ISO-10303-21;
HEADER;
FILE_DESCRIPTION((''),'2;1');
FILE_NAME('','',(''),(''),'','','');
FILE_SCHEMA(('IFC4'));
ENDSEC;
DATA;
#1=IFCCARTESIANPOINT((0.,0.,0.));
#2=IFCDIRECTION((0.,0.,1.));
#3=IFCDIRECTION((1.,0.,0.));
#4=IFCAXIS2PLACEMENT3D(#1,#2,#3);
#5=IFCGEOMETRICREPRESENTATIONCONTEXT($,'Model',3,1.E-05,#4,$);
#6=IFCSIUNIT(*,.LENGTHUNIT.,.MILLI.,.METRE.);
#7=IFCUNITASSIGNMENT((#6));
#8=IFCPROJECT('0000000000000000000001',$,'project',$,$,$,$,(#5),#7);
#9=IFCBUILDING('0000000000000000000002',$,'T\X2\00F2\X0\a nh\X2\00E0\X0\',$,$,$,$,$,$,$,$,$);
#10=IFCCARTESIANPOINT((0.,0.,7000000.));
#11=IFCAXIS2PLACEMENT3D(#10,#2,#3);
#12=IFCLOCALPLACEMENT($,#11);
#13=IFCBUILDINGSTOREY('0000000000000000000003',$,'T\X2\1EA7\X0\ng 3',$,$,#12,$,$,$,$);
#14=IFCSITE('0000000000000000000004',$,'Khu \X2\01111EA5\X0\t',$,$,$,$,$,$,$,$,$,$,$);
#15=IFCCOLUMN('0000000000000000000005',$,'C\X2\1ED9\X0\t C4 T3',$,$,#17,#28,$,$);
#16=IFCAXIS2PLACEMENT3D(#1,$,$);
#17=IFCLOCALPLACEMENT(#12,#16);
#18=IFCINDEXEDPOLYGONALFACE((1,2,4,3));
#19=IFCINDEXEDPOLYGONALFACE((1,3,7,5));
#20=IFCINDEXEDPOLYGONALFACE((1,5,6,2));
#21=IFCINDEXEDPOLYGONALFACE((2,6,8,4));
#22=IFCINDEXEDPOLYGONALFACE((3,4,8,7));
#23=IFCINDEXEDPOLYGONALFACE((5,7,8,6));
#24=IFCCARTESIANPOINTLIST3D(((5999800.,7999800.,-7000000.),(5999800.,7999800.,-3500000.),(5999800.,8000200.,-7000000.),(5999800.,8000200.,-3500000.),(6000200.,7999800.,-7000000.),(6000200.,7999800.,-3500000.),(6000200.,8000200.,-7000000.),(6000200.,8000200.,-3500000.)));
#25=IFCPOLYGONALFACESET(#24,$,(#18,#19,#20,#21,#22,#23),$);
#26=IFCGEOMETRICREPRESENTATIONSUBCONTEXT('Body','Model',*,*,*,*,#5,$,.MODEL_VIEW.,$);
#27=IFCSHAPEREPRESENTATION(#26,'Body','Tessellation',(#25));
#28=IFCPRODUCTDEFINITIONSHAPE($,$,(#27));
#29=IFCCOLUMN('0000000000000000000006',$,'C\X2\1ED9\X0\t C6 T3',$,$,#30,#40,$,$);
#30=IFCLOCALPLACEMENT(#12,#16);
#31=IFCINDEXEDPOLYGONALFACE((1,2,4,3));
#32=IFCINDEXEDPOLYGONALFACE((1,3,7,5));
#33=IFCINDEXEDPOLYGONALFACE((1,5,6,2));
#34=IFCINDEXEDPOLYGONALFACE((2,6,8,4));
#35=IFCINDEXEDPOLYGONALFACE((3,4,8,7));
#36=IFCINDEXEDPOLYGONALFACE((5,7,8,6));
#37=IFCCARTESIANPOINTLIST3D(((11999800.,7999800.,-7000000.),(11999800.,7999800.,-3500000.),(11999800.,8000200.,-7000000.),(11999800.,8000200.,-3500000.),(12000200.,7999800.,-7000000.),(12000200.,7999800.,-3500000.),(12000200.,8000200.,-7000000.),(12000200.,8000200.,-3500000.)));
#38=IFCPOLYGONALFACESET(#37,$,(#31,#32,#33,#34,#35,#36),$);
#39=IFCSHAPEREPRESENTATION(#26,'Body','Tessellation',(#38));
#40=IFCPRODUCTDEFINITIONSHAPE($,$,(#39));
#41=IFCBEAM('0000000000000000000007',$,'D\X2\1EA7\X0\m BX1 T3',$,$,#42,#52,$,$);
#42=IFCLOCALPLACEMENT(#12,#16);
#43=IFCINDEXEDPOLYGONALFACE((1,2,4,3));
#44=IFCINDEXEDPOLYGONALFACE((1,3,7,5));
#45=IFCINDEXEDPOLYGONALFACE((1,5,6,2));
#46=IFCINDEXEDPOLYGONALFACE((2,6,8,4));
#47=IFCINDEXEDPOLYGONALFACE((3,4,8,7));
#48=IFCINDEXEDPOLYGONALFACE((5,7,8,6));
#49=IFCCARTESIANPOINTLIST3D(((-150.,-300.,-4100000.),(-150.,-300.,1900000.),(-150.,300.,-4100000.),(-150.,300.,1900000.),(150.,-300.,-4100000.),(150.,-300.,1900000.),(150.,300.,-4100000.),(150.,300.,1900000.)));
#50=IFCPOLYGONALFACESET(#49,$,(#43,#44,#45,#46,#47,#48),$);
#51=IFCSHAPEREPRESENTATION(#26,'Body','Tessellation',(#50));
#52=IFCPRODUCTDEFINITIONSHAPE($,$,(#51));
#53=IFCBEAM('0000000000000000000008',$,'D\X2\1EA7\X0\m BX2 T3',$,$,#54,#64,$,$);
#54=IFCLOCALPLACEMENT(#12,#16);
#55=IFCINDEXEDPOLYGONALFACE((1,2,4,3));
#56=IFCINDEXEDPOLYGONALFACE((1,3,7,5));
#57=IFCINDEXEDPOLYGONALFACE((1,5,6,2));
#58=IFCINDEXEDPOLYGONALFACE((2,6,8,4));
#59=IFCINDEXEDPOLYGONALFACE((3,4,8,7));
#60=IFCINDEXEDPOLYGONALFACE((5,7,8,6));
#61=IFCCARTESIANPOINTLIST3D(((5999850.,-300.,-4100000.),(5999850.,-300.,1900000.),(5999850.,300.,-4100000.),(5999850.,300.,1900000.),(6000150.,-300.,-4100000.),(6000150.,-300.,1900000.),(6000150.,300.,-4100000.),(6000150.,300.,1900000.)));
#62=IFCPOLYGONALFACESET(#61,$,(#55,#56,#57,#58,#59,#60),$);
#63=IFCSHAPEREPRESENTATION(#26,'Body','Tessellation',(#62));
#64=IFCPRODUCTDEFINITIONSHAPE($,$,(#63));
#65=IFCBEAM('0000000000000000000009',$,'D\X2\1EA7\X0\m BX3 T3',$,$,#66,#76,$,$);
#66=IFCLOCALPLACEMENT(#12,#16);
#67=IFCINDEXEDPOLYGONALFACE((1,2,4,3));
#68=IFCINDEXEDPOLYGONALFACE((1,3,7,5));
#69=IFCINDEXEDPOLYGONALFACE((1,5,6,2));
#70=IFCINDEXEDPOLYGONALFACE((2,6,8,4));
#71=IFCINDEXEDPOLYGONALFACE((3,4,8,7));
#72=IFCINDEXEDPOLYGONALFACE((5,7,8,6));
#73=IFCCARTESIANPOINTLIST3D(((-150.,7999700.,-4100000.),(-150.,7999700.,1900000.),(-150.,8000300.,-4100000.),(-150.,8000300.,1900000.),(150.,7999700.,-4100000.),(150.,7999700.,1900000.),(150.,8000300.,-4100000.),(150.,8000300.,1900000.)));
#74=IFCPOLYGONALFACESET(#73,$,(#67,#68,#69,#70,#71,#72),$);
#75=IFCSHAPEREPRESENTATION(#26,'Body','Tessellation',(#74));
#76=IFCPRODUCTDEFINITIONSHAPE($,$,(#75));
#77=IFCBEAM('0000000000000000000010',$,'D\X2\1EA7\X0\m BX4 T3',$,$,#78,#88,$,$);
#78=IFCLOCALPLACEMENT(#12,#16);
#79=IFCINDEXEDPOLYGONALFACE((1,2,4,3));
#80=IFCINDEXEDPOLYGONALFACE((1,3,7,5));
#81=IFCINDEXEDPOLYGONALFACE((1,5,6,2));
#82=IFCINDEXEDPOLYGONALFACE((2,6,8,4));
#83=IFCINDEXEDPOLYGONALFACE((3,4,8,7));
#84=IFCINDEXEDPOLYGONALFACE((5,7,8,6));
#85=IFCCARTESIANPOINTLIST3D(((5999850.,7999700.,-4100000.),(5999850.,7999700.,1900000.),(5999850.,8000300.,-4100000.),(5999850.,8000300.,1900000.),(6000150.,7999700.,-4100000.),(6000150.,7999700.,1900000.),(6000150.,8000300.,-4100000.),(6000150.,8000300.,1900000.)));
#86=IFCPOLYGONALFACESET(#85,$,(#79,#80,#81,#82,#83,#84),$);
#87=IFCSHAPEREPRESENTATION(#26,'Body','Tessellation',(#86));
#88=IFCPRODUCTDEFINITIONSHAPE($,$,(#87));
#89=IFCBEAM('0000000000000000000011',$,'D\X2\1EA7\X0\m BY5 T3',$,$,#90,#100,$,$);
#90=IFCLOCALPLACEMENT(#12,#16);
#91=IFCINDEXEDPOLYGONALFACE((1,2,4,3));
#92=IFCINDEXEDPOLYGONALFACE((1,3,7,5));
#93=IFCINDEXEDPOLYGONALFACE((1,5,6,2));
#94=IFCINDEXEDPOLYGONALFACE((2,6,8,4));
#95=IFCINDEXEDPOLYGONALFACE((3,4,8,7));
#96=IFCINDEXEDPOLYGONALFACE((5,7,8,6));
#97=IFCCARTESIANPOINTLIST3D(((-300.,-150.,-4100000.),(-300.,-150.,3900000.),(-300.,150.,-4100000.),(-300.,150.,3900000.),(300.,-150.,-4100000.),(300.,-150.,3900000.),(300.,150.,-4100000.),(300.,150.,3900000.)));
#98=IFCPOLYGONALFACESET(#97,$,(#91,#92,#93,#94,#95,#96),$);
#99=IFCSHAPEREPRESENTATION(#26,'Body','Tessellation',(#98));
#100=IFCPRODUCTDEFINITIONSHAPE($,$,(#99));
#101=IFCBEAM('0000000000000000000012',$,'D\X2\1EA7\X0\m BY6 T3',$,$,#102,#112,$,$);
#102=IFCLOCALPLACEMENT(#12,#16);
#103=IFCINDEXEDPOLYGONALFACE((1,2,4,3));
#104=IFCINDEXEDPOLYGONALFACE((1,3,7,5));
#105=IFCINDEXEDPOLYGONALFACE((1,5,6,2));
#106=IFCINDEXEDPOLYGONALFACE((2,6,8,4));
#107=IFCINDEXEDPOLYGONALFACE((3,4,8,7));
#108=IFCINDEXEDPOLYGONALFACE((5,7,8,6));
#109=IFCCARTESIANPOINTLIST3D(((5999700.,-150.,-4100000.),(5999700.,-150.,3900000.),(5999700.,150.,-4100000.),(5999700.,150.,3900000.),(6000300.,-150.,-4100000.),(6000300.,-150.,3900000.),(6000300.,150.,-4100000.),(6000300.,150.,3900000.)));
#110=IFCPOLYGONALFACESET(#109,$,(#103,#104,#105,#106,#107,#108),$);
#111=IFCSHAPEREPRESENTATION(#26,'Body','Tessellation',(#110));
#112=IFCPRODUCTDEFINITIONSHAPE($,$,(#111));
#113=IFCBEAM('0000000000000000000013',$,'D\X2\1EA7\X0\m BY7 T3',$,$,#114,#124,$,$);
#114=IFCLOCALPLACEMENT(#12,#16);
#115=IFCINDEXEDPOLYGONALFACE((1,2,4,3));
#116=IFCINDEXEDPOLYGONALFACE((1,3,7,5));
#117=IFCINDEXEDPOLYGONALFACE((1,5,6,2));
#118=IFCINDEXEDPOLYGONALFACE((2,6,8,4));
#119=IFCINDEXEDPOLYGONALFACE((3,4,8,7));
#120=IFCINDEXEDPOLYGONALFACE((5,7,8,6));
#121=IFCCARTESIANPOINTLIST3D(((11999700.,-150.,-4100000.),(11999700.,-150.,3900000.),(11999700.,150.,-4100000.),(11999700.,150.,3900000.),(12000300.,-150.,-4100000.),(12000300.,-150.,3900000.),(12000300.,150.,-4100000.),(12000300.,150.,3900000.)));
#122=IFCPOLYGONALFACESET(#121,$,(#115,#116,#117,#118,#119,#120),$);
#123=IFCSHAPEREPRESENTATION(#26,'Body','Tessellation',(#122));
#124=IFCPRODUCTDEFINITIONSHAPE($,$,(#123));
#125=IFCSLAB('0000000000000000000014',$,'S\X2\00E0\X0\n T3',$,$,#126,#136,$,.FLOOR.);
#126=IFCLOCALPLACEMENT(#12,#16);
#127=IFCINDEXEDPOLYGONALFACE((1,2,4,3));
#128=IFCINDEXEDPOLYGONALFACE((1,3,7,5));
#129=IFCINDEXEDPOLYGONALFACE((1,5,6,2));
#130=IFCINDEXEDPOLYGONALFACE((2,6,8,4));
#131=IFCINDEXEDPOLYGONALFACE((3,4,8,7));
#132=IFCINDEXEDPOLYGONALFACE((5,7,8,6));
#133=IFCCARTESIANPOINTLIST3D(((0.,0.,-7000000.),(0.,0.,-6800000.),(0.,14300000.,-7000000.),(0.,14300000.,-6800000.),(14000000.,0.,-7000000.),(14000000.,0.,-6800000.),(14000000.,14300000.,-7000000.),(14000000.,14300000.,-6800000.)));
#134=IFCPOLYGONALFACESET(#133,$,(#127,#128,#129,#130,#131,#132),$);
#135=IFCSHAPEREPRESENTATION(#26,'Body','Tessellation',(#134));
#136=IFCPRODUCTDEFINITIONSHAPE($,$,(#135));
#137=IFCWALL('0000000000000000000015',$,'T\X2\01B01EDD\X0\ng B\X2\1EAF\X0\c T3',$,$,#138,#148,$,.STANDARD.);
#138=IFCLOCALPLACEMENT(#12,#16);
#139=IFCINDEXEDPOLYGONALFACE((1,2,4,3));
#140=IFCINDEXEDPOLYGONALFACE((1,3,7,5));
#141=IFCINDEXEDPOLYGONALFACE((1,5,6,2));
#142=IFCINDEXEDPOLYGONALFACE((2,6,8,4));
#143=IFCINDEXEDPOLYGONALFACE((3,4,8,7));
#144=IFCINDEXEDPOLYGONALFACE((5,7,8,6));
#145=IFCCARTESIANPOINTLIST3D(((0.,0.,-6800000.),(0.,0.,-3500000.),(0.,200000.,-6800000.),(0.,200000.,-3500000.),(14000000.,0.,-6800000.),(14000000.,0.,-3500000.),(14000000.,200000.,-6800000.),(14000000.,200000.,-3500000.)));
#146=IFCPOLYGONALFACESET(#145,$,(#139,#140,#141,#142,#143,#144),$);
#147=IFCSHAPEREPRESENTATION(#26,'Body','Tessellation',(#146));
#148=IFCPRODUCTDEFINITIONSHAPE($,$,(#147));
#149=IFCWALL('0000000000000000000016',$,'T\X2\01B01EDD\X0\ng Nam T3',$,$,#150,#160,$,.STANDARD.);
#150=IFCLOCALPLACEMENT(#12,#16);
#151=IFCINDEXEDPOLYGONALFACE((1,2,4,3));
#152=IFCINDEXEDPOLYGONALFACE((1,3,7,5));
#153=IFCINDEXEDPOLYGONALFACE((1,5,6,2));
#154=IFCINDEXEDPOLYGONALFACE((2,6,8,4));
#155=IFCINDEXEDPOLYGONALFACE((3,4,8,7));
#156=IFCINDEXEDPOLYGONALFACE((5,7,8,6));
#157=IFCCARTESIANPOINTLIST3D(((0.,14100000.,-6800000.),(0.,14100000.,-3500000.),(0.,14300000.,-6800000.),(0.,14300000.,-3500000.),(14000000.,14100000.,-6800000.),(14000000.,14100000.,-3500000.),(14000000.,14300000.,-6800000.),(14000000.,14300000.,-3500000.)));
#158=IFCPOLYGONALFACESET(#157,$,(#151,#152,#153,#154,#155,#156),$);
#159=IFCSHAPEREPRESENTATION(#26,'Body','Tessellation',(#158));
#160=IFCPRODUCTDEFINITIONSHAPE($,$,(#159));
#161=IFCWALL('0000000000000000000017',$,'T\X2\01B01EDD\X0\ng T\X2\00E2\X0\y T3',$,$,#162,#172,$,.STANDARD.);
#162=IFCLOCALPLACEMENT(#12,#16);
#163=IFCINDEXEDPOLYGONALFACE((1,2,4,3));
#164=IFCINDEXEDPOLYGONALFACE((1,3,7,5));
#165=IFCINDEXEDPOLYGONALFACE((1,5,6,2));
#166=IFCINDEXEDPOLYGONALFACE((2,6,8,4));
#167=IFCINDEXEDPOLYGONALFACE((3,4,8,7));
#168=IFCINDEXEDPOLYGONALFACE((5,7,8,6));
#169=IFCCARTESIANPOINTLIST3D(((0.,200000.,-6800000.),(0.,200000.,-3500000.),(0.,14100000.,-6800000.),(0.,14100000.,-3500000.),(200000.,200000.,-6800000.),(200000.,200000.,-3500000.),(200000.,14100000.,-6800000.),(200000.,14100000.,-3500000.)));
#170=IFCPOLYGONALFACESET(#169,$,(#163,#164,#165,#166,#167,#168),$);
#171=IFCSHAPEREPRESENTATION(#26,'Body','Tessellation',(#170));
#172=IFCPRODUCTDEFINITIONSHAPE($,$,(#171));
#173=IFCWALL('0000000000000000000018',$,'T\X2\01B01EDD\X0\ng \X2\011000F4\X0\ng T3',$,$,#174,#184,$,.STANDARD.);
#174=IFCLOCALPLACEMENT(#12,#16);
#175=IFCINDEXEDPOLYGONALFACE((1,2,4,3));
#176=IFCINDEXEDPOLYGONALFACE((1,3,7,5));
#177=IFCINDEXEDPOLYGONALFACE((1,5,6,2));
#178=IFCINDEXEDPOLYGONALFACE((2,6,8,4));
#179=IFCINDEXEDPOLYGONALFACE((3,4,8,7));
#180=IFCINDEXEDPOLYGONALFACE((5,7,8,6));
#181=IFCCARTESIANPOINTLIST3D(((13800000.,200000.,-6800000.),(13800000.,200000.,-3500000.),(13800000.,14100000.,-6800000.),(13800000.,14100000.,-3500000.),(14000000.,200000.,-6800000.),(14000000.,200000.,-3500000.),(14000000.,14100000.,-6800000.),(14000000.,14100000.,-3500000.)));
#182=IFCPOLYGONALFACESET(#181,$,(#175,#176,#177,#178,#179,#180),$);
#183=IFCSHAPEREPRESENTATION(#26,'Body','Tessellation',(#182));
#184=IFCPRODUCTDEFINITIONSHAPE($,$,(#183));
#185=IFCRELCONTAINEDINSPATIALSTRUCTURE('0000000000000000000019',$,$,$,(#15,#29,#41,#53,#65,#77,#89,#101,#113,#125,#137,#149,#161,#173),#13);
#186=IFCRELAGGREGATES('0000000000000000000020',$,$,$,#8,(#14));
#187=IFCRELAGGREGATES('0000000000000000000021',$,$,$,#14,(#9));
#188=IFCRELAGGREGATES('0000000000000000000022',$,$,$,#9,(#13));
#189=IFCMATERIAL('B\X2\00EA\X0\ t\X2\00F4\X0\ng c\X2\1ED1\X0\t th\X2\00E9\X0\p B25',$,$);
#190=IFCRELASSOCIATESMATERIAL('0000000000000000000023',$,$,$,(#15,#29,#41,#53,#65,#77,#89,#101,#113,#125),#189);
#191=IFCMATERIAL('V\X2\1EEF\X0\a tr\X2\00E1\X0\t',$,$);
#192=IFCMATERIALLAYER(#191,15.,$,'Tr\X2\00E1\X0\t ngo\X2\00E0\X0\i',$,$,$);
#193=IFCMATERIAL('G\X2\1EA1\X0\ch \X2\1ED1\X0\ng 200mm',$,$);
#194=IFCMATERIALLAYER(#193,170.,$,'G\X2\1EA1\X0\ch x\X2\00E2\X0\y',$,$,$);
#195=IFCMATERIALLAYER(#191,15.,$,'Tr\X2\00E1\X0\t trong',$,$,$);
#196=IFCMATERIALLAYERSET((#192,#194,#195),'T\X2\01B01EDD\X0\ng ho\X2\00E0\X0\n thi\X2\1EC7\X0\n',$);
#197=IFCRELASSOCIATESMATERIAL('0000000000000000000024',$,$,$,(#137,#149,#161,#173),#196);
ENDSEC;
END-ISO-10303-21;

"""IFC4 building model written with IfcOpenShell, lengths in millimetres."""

from ifc_helpers import new_model, entity, si_unit, frame, origin_with_axes, place, context, subcontext, project, spatial, indexed_curve, outline, extrude, material, layer, layer_set, layer_usage, element, save


model = new_model("IFC4")

# Units and contexts
model_context = context("Model", 3, precision=1e-05, world=origin_with_axes())
body_context = subcontext(model_context, "Body", "Model", "MODEL_VIEW")
ifc_project = project(units=[si_unit("LENGTHUNIT", "METRE", prefix="MILLI")], contexts=[model_context])

# Site, building, storey
site = spatial("IfcSite", under=ifc_project, Name="Khu đất")
building = spatial("IfcBuilding", under=site, Name="Tòa nhà")
storey_placement = place(None, frame((0.0, 0.0, 7000000.0), z_axis=(0.0, 0.0, 1.0), x_axis=(1.0, 0.0, 0.0)))
storey = spatial("IfcBuildingStorey", under=building, at=storey_placement, Name="Tầng 3")

# Columns
ifc_material_1 = material(Name="Bê tông cốt thép B25")
for number, where, z_axis, x_axis, name in (
    (1, (6000000.0, 8000000.0, -7000000.0), (0.0, 0.0, 1.0), (1.0, 0.0, 0.0), "Cột C4 T3"),
    (2, (12000000.0, 8000000.0, -7000000.0), (0.0, 0.0, 1.0), (1.0, 0.0, 0.0), "Cột C6 T3"),
):
    element("IfcColumn", number, at=place(storey_placement, frame(where, z_axis=z_axis, x_axis=x_axis)), inside=storey, material=ifc_material_1, Name=name, context=body_context, shape_type="SweptSolid", body=[
        extrude(entity("IfcRectangleProfileDef", None, None, None, 400.0, 400.0), origin_with_axes(), (0.0, 0.0, 1.0), 3500000.0),
    ])

# Beams
for number, where, z_axis, x_axis, name in (
    (3, (0.0, 0.0, -4100000.0), (0.0, 0.0, 1.0), (1.0, 0.0, 0.0), "Dầm BX1 T3"),
    (4, (6000000.0, 0.0, -4100000.0), (0.0, 0.0, 1.0), (1.0, 0.0, 0.0), "Dầm BX2 T3"),
    (5, (0.0, 8000000.0, -4100000.0), (0.0, 0.0, 1.0), (1.0, 0.0, 0.0), "Dầm BX3 T3"),
    (6, (6000000.0, 8000000.0, -4100000.0), (0.0, 0.0, 1.0), (1.0, 0.0, 0.0), "Dầm BX4 T3"),
):
    element("IfcBeam", number, at=place(storey_placement, frame(where, z_axis=z_axis, x_axis=x_axis)), inside=storey, material=ifc_material_1, Name=name, context=body_context, shape_type="SweptSolid", body=[
        extrude(entity("IfcRectangleProfileDef", None, None, None, 300.0, 600.0), origin_with_axes(), (0.0, 0.0, 1.0), 6000000.0),
    ])
for number, where, z_axis, x_axis, name in (
    (7, (0.0, 0.0, -4100000.0), (0.0, 0.0, 1.0), (0.0, 1.0, 0.0), "Dầm BY5 T3"),
    (8, (6000000.0, 0.0, -4100000.0), (0.0, 0.0, 1.0), (0.0, 1.0, 0.0), "Dầm BY6 T3"),
    (9, (12000000.0, 0.0, -4100000.0), (0.0, 0.0, 1.0), (0.0, 1.0, 0.0), "Dầm BY7 T3"),
):
    element("IfcBeam", number, at=place(storey_placement, frame(where, z_axis=z_axis, x_axis=x_axis)), inside=storey, material=ifc_material_1, Name=name, context=body_context, shape_type="SweptSolid", body=[
        extrude(entity("IfcRectangleProfileDef", None, None, None, 300.0, 600.0), origin_with_axes(), (0.0, 0.0, 1.0), 8000000.0),
    ])

# Slab
slab_placement = place(storey_placement, frame((0.0, 0.0, -7000000.0), z_axis=(0.0, 0.0, 1.0), x_axis=(1.0, 0.0, 0.0)))
element("IfcSlab", 10, at=slab_placement, inside=storey, material=ifc_material_1, Name="Sàn T3", PredefinedType="FLOOR", context=body_context, shape_type="SweptSolid", body=[
    extrude(outline(indexed_curve([(0.0, 0.0), (14000000.0, 0.0), (14000000.0, 14300000.0), (0.0, 14300000.0), (0.0, 0.0)])), None, (0.0, 0.0, 1.0), 200000.0),
])

# Walls
ifc_material_2 = material(Name="Vữa trát")
ifc_layer_1 = layer(ifc_material_2, 15.0, Name="Trát ngoài")
ifc_material_3 = material(Name="Gạch ống 200mm")
ifc_layer_2 = layer(ifc_material_3, 170.0, Name="Gạch xây")
ifc_layer_3 = layer(ifc_material_2, 15.0, Name="Trát trong")
ifc_layer_set = layer_set([ifc_layer_1, ifc_layer_2, ifc_layer_3], Name="Tường hoàn thiện")
ifc_layer_usage_1 = layer_usage(ifc_layer_set, "AXIS2", "POSITIVE", 0.0)
wall_1_placement = place(storey_placement, frame((0.0, 0.0, -6800000.0), z_axis=(0.0, 0.0, 1.0), x_axis=(1.0, 0.0, 0.0)))
element("IfcWall", 11, at=wall_1_placement, inside=storey, material=ifc_layer_usage_1, Name="Tường Bắc T3", PredefinedType="STANDARD", context=body_context, shape_type="SweptSolid", body=[
    extrude(outline(indexed_curve([(0.0, 0.0), (0.0, 200000.0), (14000000.0, 200000.0), (14000000.0, 0.0), (0.0, 0.0)], self_intersect=False)), origin_with_axes(), (0.0, 0.0, 1.0), 3300000.0),
])
ifc_layer_usage_2 = layer_usage(ifc_layer_set, "AXIS2", "POSITIVE", 0.0)
wall_2_placement = place(storey_placement, frame((0.0, 14100000.0, -6800000.0), z_axis=(0.0, 0.0, 1.0), x_axis=(1.0, 0.0, 0.0)))
element("IfcWall", 12, at=wall_2_placement, inside=storey, material=ifc_layer_usage_2, Name="Tường Nam T3", PredefinedType="STANDARD", context=body_context, shape_type="SweptSolid", body=[
    extrude(outline(indexed_curve([(0.0, 0.0), (0.0, 200000.0), (14000000.0, 200000.0), (14000000.0, 0.0), (0.0, 0.0)], self_intersect=False)), origin_with_axes(), (0.0, 0.0, 1.0), 3300000.0),
])
ifc_layer_usage_3 = layer_usage(ifc_layer_set, "AXIS2", "POSITIVE", 0.0)
wall_3_placement = place(storey_placement, frame((0.0, 200000.0, -6800000.0), z_axis=(0.0, 0.0, 1.0), x_axis=(1.0, 0.0, 0.0)))
element("IfcWall", 13, at=wall_3_placement, inside=storey, material=ifc_layer_usage_3, Name="Tường Tây T3", PredefinedType="STANDARD", context=body_context, shape_type="SweptSolid", body=[
    extrude(outline(indexed_curve([(0.0, 0.0), (0.0, 13900000.0), (200000.0, 13900000.0), (200000.0, 0.0), (0.0, 0.0)], self_intersect=False)), origin_with_axes(), (0.0, 0.0, 1.0), 3300000.0),
])
ifc_layer_usage_4 = layer_usage(ifc_layer_set, "AXIS2", "POSITIVE", 0.0)
wall_4_placement = place(storey_placement, frame((13800000.0, 200000.0, -6800000.0), z_axis=(0.0, 0.0, 1.0), x_axis=(1.0, 0.0, 0.0)))
element("IfcWall", 14, at=wall_4_placement, inside=storey, material=ifc_layer_usage_4, Name="Tường Đông T3", PredefinedType="STANDARD", context=body_context, shape_type="SweptSolid", body=[
    extrude(outline(indexed_curve([(0.0, 0.0), (0.0, 13900000.0), (200000.0, 13900000.0), (200000.0, 0.0), (0.0, 0.0)], self_intersect=False)), origin_with_axes(), (0.0, 0.0, 1.0), 3300000.0),
])

save(model, "model.ifc")
